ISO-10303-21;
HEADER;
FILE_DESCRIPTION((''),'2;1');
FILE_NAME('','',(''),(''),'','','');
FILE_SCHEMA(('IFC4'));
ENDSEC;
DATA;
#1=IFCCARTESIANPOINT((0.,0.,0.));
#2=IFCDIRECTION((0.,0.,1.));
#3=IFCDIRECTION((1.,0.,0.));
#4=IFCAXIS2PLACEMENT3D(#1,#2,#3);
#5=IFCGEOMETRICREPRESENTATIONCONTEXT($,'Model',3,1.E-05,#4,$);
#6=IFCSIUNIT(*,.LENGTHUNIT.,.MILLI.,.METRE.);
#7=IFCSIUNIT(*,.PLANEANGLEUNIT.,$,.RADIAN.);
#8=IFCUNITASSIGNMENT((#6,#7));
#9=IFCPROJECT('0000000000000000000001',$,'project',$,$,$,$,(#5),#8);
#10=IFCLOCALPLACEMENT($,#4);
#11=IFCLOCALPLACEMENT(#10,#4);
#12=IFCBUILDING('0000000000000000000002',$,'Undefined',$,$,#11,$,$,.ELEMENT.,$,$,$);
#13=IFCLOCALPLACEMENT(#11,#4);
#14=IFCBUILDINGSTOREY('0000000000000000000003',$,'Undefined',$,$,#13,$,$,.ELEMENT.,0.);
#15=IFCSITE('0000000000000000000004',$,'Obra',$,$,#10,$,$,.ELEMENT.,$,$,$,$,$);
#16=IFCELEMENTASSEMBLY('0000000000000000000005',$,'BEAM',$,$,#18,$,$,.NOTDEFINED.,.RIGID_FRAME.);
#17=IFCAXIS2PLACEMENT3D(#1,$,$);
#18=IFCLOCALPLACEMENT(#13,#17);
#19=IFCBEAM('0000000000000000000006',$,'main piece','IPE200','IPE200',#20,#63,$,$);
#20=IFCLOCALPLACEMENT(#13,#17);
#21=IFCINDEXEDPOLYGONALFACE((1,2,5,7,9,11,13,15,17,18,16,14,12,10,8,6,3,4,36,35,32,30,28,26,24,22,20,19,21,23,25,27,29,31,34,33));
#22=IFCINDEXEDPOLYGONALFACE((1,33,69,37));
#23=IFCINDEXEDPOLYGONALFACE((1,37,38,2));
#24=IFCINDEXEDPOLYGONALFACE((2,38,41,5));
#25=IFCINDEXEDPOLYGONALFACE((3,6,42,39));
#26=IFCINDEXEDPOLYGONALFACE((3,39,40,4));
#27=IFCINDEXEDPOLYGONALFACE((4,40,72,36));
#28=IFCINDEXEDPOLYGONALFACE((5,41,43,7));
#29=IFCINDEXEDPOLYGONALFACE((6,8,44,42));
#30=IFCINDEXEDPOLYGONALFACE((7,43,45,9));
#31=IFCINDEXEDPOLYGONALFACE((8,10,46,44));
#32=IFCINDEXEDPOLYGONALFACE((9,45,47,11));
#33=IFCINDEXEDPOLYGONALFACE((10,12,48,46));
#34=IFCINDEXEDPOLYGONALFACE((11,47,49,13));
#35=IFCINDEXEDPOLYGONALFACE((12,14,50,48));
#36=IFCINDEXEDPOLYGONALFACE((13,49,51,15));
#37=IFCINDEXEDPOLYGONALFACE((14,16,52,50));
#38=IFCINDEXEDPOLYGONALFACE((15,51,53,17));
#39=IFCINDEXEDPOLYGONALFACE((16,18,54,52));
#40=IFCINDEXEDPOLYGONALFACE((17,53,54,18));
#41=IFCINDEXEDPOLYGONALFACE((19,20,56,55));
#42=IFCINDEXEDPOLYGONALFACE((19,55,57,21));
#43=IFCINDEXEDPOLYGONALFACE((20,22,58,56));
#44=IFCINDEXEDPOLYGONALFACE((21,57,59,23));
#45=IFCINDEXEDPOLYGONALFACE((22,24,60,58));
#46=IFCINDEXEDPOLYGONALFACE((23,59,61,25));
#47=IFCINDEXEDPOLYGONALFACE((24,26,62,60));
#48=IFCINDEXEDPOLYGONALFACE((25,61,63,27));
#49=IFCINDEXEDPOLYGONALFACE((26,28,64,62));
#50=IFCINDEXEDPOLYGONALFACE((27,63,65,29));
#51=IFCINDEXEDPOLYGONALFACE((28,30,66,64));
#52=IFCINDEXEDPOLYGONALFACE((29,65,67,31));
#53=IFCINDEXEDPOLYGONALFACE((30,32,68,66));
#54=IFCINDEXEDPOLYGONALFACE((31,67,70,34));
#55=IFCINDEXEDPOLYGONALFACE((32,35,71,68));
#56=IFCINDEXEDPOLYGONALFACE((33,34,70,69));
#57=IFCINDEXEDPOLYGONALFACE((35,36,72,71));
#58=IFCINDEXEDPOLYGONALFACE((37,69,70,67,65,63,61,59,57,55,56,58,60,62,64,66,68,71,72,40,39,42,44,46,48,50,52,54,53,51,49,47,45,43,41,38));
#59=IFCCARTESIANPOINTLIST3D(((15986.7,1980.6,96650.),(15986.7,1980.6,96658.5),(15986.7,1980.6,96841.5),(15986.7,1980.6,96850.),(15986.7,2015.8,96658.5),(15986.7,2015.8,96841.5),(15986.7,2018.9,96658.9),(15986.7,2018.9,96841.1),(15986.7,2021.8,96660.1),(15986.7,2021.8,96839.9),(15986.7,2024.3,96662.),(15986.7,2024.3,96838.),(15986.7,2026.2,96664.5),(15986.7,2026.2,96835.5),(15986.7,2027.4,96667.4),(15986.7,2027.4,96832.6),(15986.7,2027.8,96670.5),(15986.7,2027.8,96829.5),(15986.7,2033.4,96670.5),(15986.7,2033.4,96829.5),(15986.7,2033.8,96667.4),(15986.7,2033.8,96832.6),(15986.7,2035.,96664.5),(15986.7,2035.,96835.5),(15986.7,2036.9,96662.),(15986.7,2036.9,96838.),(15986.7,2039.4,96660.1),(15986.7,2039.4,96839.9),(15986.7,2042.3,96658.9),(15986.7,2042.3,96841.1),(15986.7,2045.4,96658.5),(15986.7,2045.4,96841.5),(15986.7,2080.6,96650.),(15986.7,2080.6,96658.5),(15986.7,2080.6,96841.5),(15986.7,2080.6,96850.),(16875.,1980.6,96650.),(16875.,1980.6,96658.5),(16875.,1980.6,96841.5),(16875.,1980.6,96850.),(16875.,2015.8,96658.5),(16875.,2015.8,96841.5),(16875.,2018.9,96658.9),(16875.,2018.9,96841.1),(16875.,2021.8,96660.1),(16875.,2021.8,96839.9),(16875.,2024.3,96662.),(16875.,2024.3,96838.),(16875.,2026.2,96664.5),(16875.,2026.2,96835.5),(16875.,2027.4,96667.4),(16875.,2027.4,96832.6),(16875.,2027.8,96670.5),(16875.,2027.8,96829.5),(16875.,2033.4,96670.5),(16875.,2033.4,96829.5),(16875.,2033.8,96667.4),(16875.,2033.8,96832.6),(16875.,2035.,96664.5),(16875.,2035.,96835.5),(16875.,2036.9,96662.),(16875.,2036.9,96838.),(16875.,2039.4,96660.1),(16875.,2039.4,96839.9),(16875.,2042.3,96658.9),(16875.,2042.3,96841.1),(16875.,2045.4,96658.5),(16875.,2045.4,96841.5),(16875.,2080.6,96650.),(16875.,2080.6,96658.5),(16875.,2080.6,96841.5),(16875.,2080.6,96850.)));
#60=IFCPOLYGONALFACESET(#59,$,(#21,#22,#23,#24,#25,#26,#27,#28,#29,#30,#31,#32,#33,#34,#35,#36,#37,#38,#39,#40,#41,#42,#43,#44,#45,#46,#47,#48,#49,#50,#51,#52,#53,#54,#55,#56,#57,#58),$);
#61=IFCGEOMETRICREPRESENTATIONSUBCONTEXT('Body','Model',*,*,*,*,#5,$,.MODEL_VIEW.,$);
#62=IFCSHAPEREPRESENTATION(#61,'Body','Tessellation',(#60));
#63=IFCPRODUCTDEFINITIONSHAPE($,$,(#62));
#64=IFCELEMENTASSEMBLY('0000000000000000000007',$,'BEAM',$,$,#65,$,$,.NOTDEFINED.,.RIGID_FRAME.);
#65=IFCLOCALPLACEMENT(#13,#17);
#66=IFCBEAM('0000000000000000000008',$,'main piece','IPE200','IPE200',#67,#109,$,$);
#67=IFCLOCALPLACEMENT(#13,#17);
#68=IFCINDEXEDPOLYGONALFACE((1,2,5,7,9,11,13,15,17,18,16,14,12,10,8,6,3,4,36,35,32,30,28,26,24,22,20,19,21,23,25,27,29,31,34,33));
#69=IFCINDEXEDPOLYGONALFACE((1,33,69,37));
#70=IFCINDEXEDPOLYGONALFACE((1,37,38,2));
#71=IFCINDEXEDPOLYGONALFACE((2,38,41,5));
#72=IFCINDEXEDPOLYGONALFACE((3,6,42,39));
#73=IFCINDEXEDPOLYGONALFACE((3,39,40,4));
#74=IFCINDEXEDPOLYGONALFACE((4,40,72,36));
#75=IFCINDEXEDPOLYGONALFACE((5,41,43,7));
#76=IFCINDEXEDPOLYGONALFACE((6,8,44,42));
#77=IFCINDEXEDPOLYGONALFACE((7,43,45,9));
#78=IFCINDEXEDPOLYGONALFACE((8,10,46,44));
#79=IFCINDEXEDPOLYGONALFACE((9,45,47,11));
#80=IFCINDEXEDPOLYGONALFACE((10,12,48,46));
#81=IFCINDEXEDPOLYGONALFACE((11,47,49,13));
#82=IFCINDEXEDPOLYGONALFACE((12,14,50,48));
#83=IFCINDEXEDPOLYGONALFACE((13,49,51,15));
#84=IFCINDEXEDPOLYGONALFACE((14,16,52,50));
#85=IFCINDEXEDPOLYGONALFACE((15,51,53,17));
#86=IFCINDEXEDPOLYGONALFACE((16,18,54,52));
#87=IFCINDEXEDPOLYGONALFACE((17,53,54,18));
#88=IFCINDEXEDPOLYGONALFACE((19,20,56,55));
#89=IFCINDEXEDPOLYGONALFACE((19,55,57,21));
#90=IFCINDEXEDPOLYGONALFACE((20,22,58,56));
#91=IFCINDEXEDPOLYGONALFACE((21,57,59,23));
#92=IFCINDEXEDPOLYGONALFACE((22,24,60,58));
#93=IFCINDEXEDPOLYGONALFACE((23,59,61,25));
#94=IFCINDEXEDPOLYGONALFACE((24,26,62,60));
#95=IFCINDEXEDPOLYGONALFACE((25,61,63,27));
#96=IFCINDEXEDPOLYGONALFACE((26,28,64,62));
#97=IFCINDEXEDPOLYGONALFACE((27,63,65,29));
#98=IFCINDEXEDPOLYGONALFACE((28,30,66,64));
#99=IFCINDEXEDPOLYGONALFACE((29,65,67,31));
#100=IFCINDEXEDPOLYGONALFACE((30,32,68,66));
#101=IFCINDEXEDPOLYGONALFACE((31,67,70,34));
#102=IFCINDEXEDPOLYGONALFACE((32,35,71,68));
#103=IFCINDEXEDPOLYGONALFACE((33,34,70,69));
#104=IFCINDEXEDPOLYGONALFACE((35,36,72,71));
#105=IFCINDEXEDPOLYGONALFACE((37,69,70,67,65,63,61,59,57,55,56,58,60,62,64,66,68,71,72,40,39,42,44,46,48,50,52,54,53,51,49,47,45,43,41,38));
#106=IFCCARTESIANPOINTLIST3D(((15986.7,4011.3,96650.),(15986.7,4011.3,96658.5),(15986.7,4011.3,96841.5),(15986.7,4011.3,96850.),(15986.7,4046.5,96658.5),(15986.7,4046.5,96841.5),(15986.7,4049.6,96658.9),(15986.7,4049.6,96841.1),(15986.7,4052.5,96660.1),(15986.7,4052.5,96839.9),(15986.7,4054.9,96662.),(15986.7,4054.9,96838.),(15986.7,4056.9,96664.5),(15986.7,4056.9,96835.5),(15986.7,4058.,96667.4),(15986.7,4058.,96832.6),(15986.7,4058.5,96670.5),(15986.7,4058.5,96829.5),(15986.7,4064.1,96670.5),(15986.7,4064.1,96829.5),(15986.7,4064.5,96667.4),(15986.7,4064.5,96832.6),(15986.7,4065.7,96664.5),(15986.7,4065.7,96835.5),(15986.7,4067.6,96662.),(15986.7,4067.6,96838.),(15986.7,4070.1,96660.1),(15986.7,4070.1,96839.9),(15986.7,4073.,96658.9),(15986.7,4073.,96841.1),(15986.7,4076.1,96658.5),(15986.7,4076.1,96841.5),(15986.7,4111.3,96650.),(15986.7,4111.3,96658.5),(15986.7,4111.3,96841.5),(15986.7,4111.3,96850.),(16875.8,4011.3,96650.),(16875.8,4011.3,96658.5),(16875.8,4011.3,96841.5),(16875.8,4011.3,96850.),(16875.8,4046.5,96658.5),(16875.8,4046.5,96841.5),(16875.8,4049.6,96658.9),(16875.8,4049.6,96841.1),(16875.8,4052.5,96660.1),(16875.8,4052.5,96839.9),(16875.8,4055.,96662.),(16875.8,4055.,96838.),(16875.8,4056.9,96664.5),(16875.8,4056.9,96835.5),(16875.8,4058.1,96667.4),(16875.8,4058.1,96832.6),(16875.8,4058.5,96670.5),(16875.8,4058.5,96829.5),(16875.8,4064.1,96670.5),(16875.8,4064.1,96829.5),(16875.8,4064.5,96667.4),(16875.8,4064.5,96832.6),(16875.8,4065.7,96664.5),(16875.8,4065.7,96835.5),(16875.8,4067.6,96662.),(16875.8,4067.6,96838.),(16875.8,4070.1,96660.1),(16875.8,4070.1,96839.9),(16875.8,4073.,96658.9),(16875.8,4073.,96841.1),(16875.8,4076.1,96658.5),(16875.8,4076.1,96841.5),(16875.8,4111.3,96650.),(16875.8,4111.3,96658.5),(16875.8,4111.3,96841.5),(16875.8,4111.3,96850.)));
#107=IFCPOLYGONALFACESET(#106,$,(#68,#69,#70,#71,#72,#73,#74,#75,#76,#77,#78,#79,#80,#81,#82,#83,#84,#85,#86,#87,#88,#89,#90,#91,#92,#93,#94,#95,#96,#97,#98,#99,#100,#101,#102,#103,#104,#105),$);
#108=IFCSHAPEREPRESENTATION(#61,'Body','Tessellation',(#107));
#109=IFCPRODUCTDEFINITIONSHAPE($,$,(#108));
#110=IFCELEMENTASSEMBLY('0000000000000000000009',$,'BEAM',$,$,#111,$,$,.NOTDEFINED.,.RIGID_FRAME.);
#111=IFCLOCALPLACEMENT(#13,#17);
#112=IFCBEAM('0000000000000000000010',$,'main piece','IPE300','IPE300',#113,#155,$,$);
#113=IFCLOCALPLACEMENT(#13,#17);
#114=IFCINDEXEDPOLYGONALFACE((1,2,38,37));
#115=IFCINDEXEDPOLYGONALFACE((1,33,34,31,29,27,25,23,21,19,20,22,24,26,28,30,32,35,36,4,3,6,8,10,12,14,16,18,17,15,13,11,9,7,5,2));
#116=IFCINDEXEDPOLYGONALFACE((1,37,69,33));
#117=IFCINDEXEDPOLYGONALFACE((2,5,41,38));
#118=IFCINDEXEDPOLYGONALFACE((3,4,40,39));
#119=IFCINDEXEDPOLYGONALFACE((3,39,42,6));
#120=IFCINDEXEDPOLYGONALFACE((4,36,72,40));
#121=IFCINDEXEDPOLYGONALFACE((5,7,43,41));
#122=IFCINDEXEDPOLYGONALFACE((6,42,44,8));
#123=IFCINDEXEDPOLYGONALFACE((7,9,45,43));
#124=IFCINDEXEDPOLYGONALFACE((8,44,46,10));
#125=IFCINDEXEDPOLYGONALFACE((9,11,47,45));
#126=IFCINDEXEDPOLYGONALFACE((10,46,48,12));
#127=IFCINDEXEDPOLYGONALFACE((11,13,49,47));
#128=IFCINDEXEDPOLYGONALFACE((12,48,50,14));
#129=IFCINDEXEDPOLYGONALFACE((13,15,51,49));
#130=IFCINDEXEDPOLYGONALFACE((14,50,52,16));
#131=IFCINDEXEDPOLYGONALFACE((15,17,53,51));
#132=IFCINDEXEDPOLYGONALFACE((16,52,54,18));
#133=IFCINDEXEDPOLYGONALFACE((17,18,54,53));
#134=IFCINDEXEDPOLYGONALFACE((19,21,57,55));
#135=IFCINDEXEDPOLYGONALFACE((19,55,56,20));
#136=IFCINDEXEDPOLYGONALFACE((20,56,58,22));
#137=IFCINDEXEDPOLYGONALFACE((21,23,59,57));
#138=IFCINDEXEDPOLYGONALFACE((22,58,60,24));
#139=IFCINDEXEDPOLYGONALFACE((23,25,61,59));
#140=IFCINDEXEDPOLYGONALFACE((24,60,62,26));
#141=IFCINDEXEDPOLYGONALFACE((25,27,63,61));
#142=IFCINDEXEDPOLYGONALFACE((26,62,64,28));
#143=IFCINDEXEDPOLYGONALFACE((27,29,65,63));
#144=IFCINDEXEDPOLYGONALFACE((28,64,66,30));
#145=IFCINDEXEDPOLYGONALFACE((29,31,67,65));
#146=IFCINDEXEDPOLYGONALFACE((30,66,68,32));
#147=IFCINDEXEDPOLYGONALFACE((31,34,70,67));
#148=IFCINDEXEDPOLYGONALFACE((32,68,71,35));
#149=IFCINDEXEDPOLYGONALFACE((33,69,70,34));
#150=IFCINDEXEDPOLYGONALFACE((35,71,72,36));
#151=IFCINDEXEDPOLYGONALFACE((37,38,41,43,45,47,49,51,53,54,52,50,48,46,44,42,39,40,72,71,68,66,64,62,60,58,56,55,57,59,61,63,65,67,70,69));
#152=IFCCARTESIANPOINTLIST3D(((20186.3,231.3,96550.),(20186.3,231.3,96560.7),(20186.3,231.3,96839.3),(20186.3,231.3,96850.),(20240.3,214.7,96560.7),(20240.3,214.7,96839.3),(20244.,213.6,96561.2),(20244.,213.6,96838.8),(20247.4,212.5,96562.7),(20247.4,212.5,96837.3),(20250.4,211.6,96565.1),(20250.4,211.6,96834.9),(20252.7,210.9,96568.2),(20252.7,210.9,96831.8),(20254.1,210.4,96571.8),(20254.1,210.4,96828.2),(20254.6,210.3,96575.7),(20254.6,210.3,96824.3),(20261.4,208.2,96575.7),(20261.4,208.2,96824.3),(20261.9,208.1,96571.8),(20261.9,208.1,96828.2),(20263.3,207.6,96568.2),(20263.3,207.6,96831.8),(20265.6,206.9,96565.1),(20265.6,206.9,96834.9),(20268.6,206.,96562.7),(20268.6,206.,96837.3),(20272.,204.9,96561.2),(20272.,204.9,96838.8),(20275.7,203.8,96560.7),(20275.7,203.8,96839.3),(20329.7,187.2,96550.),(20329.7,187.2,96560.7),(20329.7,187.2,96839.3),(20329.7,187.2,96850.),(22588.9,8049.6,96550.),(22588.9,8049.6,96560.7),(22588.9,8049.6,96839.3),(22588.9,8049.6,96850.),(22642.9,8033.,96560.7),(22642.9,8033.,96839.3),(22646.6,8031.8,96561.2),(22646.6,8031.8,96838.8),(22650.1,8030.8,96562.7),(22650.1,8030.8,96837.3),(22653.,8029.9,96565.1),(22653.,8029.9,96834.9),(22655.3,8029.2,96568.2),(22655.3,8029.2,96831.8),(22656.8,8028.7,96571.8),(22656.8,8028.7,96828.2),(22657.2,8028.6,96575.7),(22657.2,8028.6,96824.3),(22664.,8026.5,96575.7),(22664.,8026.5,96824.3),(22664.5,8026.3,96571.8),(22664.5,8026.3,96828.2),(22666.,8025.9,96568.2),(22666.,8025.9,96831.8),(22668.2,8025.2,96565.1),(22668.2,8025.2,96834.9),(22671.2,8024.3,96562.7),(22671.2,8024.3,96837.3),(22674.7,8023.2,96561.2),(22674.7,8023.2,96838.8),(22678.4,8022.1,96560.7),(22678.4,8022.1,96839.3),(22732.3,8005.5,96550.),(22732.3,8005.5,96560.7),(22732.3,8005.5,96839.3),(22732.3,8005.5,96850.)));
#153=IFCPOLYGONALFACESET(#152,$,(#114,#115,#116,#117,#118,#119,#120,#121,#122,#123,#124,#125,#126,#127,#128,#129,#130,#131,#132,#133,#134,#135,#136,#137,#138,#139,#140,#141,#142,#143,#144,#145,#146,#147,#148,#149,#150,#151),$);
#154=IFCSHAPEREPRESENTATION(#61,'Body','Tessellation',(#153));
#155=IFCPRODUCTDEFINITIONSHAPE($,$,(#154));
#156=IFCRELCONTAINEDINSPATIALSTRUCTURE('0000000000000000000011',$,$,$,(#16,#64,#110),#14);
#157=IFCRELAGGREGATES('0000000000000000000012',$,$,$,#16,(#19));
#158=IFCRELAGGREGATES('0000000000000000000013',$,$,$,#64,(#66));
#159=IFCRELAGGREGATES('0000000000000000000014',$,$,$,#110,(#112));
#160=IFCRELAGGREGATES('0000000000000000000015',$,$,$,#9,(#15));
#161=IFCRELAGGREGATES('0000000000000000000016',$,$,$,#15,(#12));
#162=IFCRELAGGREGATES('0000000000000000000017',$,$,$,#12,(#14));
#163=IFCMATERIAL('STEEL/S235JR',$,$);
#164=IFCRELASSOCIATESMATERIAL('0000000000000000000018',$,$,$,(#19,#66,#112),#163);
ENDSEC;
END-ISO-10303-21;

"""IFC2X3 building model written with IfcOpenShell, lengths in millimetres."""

from ifc_helpers import new_model, si_unit, frame, origin_with_axes, origin_2d_with_axis, place, context, subcontext, project, spatial, i_section, extrude, material, element, aggregate, save


model = new_model("IFC2X3")

# Units and contexts
model_context = context("Model", 3, precision=1e-05, world=origin_with_axes())
body_context = subcontext(model_context, "Body", "Model", "MODEL_VIEW")
ifc_project = project(units=[si_unit("LENGTHUNIT", "METRE", prefix="MILLI"), si_unit("PLANEANGLEUNIT", "RADIAN")], contexts=[model_context])

# Site, building, storey
site_placement = place(None, origin_with_axes())
site = spatial("IfcSite", under=ifc_project, at=site_placement, Name="Obra", CompositionType="ELEMENT")
building_placement = place(site_placement, origin_with_axes())
building = spatial("IfcBuilding", under=site, at=building_placement, Name="Undefined", CompositionType="ELEMENT")
storey_placement = place(building_placement, origin_with_axes())
storey = spatial("IfcBuildingStorey", under=building, at=storey_placement, Name="Undefined", CompositionType="ELEMENT", Elevation=0.0)

# Element assemblies, beams
ifc_material = material(Name="STEEL/S235JR")
assembly_1_placement = place(storey_placement, origin_with_axes())
assembly_1 = element("IfcElementAssembly", 1, at=assembly_1_placement, inside=storey, Name="BEAM", AssemblyPlace="NOTDEFINED", PredefinedType="RIGID_FRAME")
beam_1_placement = place(assembly_1_placement, frame((16875.0, 2030.6, 96750.0), z_axis=(0.0, 0.0, 1.0), x_axis=(-1.0, 0.0, 0.0)))
beam_1 = element("IfcBeam", 2, at=beam_1_placement, material=ifc_material, Name="main piece", Description="IPE200", ObjectType="IPE200", context=body_context, shape_type="SweptSolid", body=[
    extrude(i_section(OverallWidth=100.0, OverallDepth=200.0, WebThickness=5.6, FlangeThickness=8.5, FilletRadius=12.0, at=origin_2d_with_axis()), frame((888.3, 0.0, 0.0), z_axis=(-1.0, 0.0, 0.0), x_axis=(0.0, -1.0, 0.0)), (0.0, 0.0, 1.0), 888.3),
])
aggregate(assembly_1, [beam_1])
assembly_2_placement = place(storey_placement, origin_with_axes())
assembly_2 = element("IfcElementAssembly", 3, at=assembly_2_placement, inside=storey, Name="BEAM", AssemblyPlace="NOTDEFINED", PredefinedType="RIGID_FRAME")
beam_2_placement = place(assembly_2_placement, frame((16875.8, 4061.3, 96750.0), z_axis=(0.0, 0.0, 1.0), x_axis=(-1.0, -0.000044, 0.0)))
beam_2 = element("IfcBeam", 4, at=beam_2_placement, material=ifc_material, Name="main piece", Description="IPE200", ObjectType="IPE200", context=body_context, shape_type="SweptSolid", body=[
    extrude(i_section(OverallWidth=100.0, OverallDepth=200.0, WebThickness=5.6, FlangeThickness=8.5, FilletRadius=12.0, at=origin_2d_with_axis()), frame((889.1, 0.0, 0.0), z_axis=(-1.0, 0.0, 0.0), x_axis=(0.0, -1.0, 0.0)), (0.0, 0.0, 1.0), 889.1),
])
aggregate(assembly_2, [beam_2])
assembly_3_placement = place(storey_placement, origin_with_axes())
assembly_3 = element("IfcElementAssembly", 5, at=assembly_3_placement, inside=storey, Name="BEAM", AssemblyPlace="NOTDEFINED", PredefinedType="RIGID_FRAME")
beam_3_placement = place(assembly_3_placement, frame((20258.0, 209.2, 96700.0), z_axis=(0.0, 0.0, 1.0), x_axis=(0.293752, 0.955882, 0.0)))
beam_3 = element("IfcBeam", 6, at=beam_3_placement, material=ifc_material, Name="main piece", Description="IPE300", ObjectType="IPE300", context=body_context, shape_type="SweptSolid", body=[
    extrude(i_section(OverallWidth=150.0, OverallDepth=300.0, WebThickness=7.1, FlangeThickness=10.7, FilletRadius=15.0, at=origin_2d_with_axis()), frame((8179.1, 0.0, 0.0), z_axis=(-1.0, 0.0, 0.0), x_axis=(0.0, -1.0, 0.0)), (0.0, 0.0, 1.0), 8179.1),
])
aggregate(assembly_3, [beam_3])

save(model, "model.ifc")
